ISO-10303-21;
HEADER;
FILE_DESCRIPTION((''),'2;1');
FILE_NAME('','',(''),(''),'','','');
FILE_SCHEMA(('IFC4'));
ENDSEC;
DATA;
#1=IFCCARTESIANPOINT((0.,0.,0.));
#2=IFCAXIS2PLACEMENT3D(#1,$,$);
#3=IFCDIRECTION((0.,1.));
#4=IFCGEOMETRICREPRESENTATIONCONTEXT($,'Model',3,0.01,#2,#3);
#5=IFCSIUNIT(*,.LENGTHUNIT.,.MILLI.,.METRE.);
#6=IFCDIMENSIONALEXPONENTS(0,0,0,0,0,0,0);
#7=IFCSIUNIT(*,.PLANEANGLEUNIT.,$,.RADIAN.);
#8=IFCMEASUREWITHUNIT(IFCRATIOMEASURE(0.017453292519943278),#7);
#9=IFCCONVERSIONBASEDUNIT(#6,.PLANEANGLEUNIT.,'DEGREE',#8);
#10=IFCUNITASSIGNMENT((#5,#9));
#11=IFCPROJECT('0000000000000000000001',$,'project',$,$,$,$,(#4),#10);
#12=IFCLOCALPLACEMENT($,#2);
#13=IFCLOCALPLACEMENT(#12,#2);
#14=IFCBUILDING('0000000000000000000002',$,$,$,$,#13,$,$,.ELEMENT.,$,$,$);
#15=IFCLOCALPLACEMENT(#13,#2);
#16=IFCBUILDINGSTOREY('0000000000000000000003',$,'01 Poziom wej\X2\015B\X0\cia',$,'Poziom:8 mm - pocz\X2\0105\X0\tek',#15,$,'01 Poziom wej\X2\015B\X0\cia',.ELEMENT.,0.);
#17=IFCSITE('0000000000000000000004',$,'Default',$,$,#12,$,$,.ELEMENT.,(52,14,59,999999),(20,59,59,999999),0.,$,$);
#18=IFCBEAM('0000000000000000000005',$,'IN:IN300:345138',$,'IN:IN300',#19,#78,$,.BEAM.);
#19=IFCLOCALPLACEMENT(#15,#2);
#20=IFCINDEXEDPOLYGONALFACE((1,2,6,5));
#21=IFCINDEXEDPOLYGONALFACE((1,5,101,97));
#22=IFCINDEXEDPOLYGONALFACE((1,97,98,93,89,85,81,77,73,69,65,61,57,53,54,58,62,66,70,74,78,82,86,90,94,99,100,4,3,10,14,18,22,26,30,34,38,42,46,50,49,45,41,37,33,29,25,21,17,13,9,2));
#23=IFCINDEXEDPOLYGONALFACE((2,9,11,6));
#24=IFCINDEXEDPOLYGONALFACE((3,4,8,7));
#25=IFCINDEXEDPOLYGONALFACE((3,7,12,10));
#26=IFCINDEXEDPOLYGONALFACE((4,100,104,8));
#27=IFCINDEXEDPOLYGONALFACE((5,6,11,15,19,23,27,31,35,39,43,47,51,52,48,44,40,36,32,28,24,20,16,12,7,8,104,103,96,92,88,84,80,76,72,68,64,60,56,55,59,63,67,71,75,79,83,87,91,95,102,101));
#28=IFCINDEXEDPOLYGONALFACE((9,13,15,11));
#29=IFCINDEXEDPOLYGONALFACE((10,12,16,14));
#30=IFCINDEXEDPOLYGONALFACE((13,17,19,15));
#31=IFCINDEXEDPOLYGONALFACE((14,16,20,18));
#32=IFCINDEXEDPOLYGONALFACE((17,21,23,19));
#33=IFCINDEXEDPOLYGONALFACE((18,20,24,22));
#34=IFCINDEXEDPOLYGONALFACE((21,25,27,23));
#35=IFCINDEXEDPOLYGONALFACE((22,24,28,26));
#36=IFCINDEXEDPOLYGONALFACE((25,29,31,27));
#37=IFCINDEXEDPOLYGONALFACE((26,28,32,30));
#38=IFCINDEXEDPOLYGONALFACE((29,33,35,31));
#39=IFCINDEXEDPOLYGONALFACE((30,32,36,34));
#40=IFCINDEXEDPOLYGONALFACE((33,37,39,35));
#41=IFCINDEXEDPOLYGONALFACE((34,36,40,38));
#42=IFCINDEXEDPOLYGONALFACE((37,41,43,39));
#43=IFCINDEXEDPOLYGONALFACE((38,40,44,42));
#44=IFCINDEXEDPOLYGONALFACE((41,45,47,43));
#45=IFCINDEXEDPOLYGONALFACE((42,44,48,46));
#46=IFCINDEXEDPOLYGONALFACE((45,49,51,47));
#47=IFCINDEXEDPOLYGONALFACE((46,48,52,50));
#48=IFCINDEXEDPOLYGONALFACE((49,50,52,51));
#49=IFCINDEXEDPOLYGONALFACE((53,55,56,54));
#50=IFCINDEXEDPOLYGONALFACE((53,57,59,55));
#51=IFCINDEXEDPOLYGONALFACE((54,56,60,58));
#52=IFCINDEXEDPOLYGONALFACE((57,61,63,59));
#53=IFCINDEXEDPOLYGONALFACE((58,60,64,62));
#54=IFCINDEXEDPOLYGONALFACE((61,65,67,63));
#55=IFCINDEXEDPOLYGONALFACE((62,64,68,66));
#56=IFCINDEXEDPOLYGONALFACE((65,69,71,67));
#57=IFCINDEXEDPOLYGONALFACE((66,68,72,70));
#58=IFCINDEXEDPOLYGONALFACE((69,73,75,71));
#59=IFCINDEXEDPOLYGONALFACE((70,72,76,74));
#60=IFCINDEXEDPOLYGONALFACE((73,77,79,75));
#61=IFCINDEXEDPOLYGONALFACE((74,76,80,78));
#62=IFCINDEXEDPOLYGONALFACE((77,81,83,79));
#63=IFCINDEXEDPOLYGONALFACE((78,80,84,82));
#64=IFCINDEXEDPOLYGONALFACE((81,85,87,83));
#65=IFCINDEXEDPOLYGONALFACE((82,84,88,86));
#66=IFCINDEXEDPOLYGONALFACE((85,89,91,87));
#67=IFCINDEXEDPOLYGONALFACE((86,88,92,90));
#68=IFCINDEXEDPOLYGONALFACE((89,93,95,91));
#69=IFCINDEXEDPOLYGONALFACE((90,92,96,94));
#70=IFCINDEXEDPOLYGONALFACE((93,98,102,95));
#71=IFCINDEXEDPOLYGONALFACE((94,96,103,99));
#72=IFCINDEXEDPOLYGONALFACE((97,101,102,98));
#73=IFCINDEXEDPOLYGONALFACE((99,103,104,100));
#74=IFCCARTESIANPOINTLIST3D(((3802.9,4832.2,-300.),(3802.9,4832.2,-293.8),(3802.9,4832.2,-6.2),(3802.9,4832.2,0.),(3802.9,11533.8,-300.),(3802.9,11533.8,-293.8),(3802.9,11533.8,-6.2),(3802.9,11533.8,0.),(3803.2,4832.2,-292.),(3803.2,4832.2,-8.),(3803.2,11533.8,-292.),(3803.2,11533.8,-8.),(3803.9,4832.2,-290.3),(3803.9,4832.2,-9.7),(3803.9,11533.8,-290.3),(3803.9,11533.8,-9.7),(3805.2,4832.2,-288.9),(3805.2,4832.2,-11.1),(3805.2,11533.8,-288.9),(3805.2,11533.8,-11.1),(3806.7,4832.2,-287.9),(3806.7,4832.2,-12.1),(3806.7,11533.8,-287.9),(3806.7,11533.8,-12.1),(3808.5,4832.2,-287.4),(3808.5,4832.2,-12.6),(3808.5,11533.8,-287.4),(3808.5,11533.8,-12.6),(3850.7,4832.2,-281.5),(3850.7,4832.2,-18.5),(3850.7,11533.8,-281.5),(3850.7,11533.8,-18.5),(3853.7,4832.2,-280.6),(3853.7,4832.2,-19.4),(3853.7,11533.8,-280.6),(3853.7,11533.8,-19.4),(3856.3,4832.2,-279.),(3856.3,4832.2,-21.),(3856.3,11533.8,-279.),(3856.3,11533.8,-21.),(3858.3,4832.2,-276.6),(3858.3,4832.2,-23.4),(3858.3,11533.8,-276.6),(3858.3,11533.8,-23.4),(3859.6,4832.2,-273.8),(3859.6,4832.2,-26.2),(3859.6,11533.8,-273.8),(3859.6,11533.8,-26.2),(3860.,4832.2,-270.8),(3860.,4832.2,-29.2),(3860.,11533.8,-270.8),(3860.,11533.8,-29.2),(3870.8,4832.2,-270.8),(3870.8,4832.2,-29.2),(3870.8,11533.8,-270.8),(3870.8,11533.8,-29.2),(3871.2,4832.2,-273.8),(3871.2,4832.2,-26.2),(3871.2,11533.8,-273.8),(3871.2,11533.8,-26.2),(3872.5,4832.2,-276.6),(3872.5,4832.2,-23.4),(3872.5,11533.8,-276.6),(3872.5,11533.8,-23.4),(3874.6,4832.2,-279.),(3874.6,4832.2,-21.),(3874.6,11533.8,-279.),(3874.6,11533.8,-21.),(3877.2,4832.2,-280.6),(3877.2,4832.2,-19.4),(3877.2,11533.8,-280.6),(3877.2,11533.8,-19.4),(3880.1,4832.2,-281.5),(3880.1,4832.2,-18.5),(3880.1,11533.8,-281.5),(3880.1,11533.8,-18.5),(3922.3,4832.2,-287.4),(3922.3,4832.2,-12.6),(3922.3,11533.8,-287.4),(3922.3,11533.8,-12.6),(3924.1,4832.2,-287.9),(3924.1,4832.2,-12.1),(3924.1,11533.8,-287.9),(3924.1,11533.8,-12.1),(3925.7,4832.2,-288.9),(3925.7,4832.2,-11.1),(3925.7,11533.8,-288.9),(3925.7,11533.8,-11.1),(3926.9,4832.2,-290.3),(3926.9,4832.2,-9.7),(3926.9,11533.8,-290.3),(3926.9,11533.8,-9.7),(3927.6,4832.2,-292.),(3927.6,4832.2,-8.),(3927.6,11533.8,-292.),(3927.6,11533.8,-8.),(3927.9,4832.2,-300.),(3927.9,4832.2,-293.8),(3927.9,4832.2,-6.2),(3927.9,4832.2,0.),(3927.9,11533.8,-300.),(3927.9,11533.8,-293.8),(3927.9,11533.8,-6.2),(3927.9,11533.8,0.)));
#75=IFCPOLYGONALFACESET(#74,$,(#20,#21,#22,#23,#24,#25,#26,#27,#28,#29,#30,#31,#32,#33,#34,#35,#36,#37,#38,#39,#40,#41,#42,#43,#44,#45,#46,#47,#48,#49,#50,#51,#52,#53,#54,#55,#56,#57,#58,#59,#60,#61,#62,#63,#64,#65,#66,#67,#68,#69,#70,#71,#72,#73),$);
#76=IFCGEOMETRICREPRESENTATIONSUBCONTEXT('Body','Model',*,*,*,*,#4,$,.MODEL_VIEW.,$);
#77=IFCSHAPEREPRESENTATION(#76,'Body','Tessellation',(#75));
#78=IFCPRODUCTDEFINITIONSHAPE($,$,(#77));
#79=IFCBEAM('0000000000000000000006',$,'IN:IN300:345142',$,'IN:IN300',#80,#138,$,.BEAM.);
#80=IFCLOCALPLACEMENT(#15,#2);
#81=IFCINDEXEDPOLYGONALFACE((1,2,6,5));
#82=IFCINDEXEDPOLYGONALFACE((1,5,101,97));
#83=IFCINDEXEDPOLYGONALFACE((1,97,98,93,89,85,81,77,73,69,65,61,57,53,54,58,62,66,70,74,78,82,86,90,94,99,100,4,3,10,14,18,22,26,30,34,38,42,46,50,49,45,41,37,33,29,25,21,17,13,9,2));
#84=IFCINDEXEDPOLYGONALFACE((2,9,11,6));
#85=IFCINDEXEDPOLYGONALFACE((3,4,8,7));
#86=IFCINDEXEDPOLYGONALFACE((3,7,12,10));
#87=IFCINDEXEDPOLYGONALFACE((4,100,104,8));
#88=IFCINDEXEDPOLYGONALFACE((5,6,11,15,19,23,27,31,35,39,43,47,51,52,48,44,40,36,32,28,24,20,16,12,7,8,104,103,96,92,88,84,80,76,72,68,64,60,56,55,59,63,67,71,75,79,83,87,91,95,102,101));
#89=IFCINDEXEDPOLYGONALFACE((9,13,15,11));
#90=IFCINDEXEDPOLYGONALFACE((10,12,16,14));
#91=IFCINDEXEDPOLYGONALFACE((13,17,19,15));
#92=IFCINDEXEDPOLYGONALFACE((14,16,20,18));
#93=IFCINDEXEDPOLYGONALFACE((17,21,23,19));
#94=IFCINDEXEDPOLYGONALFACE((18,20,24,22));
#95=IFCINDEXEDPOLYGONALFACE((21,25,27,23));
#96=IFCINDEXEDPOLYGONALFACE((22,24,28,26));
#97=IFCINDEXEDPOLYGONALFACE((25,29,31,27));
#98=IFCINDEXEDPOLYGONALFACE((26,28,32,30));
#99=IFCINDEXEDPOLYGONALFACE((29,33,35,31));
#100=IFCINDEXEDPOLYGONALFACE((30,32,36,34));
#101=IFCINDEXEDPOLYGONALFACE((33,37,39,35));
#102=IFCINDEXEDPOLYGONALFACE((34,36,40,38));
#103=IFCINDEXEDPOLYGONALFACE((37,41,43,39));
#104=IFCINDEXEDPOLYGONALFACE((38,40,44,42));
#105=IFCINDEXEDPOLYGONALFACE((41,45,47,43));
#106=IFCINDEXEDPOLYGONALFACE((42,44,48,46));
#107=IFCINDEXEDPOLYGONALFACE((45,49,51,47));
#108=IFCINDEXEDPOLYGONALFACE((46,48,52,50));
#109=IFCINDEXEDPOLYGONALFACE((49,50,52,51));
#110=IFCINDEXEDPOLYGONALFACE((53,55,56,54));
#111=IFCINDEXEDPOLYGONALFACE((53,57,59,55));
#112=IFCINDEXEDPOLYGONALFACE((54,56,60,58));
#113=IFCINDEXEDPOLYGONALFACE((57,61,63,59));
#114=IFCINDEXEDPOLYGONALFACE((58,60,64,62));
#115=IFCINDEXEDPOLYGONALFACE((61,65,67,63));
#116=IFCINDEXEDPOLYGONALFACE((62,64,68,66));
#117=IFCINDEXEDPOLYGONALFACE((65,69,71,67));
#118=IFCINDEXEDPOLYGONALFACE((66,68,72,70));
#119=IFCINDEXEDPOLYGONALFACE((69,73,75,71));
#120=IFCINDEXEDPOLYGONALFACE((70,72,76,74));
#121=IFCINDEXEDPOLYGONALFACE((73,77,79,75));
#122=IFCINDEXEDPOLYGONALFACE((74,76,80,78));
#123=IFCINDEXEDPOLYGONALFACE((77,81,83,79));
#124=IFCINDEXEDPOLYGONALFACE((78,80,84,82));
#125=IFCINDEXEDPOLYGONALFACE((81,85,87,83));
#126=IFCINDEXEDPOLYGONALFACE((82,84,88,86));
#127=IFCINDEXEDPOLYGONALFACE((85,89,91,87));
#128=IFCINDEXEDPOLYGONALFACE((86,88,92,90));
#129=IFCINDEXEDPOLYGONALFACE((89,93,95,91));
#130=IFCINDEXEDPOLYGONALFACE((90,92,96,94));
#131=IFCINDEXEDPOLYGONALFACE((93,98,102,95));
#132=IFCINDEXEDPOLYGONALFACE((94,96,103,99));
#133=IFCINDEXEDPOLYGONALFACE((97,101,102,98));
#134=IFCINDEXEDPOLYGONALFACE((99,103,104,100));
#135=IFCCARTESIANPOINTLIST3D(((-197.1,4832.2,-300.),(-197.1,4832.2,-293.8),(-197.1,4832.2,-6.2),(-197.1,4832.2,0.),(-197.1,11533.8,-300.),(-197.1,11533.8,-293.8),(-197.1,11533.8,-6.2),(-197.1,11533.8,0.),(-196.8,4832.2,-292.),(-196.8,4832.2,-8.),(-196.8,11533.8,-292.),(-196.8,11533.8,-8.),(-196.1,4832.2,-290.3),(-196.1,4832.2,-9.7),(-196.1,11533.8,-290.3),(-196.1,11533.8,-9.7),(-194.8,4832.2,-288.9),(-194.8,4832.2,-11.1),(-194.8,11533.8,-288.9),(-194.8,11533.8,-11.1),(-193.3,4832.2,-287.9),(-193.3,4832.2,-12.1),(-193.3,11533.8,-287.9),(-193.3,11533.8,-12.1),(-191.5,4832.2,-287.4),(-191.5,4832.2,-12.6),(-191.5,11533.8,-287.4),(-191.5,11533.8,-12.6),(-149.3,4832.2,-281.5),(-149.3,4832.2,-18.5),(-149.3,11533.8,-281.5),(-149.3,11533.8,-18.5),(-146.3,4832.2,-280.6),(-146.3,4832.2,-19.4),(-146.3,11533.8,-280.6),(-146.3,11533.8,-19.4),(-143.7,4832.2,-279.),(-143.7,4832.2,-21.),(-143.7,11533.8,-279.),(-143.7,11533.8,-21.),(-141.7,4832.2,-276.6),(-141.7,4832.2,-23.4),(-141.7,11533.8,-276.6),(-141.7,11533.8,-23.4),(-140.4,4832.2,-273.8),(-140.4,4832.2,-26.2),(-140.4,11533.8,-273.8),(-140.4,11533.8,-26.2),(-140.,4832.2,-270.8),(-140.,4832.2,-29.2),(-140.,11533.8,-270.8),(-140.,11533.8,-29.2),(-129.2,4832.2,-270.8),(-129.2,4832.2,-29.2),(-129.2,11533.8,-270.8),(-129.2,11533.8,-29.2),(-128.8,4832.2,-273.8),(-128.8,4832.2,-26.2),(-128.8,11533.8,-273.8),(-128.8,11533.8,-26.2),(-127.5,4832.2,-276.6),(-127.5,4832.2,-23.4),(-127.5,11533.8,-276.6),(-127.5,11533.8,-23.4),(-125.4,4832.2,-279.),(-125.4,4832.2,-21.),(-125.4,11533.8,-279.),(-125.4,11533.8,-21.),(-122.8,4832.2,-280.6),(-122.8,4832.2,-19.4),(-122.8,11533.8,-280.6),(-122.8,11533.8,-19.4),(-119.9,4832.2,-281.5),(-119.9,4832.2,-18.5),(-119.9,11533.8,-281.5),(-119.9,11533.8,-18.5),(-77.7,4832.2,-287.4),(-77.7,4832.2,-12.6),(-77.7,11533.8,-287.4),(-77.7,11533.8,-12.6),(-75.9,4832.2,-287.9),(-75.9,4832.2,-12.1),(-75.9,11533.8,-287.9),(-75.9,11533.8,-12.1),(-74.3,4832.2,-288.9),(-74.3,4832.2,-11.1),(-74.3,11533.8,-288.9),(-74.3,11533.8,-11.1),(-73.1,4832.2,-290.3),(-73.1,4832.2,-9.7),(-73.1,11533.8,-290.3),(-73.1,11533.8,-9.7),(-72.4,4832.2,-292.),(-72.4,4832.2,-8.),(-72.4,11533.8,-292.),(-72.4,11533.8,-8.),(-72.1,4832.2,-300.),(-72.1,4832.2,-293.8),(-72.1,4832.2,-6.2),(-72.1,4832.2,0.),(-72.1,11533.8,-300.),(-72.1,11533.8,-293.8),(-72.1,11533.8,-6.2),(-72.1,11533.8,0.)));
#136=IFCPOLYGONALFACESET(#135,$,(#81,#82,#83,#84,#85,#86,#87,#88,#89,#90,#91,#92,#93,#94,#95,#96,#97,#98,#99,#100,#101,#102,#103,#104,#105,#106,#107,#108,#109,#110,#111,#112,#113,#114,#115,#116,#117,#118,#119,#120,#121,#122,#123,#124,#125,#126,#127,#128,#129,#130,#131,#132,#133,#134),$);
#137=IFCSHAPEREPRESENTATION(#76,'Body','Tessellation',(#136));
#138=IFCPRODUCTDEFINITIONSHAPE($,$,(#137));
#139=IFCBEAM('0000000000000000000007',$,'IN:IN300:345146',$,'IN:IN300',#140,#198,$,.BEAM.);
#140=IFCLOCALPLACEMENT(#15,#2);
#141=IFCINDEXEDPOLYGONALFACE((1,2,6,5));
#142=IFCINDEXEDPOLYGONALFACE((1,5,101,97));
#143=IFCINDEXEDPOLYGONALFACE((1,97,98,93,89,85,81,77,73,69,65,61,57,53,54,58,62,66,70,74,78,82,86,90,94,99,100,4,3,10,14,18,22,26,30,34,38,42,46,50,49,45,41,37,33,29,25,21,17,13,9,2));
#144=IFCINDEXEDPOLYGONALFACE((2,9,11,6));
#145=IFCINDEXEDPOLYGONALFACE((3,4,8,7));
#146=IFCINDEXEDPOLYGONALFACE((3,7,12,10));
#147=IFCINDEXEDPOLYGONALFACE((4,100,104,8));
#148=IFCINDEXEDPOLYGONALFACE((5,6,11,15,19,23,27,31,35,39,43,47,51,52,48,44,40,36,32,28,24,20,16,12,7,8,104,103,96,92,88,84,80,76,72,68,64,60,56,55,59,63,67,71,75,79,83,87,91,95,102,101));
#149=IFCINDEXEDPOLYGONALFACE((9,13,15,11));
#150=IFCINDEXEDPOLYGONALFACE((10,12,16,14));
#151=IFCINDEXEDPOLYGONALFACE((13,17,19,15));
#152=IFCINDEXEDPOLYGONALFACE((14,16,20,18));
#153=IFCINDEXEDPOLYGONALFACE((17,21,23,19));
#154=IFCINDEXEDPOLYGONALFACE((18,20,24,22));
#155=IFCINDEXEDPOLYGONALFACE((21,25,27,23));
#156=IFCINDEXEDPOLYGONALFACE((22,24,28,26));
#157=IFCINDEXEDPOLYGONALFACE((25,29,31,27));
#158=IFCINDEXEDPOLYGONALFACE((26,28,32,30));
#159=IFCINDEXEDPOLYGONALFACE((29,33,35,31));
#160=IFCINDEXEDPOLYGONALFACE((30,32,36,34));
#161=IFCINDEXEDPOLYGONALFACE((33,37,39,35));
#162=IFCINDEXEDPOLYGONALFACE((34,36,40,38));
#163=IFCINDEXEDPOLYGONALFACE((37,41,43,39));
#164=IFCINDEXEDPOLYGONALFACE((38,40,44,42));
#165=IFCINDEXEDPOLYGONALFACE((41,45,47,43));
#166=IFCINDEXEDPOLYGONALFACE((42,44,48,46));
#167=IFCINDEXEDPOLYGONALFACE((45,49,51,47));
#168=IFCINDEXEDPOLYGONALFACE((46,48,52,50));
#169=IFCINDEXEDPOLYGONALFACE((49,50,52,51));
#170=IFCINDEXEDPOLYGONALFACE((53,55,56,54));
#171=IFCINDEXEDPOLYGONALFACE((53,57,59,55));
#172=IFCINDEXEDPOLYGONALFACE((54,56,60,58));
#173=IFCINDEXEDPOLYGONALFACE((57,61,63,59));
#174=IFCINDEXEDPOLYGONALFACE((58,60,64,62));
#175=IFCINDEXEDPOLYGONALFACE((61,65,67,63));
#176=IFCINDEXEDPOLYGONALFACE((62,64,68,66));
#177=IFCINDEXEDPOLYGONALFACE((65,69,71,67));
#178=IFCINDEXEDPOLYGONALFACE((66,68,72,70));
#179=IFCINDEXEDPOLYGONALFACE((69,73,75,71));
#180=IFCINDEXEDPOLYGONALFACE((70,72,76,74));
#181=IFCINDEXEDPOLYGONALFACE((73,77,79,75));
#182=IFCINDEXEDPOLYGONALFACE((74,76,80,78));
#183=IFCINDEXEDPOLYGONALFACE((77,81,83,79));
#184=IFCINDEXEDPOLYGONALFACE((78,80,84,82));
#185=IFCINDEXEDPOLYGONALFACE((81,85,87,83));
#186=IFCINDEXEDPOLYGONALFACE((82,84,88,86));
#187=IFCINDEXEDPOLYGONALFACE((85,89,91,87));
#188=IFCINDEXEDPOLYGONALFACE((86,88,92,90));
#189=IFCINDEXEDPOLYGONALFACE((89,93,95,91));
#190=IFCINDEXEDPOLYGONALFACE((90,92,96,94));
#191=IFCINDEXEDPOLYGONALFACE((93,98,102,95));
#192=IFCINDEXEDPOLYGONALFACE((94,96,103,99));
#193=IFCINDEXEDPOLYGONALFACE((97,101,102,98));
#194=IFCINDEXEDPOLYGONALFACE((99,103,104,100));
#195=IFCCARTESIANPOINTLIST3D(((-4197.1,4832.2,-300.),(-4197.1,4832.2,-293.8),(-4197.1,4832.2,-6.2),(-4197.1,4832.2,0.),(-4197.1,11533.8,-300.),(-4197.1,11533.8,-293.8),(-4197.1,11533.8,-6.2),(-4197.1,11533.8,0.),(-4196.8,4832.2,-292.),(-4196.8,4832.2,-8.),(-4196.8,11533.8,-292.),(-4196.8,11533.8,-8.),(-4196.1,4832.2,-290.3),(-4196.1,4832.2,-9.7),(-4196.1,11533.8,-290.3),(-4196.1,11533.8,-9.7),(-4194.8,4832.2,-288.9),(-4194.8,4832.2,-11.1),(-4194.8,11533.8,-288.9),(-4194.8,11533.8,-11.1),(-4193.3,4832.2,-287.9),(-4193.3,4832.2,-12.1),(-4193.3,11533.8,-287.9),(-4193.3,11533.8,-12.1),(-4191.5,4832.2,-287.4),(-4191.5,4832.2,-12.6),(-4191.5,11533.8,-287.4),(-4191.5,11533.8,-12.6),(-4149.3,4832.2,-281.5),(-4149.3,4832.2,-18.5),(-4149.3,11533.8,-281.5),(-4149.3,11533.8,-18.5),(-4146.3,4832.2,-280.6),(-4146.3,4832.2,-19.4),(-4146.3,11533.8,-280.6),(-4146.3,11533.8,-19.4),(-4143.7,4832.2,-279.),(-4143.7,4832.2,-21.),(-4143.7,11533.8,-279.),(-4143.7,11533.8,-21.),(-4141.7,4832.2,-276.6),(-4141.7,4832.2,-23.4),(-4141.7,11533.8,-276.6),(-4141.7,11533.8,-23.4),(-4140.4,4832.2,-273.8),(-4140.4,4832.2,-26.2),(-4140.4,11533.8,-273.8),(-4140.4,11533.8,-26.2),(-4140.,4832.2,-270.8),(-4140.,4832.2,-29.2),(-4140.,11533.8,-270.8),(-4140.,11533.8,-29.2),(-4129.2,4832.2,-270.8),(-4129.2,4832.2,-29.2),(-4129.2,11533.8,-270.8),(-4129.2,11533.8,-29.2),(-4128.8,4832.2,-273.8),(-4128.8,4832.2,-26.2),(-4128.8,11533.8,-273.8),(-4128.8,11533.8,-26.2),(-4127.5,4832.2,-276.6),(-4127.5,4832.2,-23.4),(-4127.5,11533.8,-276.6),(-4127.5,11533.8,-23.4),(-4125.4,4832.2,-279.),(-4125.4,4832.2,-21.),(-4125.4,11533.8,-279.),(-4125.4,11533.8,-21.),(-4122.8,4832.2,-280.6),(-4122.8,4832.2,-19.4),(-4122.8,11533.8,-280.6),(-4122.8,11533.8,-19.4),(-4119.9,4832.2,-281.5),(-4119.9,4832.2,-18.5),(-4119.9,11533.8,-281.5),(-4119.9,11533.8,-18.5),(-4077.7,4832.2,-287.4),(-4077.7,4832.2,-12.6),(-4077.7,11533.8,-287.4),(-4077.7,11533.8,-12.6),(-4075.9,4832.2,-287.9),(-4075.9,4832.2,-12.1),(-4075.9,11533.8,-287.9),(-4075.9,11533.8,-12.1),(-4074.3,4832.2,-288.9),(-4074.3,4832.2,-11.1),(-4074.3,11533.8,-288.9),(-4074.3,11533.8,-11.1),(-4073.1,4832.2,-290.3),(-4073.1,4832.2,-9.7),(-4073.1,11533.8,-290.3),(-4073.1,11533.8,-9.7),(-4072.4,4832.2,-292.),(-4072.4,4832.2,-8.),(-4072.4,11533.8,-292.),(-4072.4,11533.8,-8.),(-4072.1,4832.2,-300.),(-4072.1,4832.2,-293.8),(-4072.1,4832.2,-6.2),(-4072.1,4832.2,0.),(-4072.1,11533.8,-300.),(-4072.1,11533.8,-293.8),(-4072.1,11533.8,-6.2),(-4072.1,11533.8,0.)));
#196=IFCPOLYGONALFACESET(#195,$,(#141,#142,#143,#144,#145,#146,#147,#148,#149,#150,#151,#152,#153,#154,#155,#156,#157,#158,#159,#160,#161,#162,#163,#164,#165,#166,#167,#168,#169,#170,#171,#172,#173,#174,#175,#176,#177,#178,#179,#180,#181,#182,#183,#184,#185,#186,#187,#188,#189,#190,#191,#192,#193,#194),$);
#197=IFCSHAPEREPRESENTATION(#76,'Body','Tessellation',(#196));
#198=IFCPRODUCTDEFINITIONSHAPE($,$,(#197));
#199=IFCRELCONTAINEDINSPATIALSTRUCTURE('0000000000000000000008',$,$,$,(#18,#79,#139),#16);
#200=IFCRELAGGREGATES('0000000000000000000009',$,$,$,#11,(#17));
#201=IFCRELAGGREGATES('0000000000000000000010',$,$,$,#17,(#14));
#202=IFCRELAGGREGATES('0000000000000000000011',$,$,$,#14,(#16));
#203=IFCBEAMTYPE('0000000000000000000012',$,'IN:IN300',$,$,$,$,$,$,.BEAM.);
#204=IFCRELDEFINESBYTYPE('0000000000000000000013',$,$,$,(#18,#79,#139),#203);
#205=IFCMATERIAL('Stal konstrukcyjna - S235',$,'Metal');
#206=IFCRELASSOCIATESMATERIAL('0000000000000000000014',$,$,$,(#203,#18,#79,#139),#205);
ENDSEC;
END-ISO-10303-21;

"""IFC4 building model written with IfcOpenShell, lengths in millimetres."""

from ifc_helpers import new_model, entity, si_unit, converted_unit, direction, frame, origin, place, context, subcontext, project, spatial, line, arc, indexed_curve, outline, extrude, source, transform, mapped, material, type_object, type_shapes, element, save


model = new_model("IFC4")

# Units and contexts
model_context = context("Model", 3, precision=0.01, world=origin(), true_north=direction((0.0, 1.0)))
body_context = subcontext(model_context, "Body", "Model", "MODEL_VIEW")
ifc_project = project(units=[si_unit("LENGTHUNIT", "METRE", prefix="MILLI"), converted_unit("PLANEANGLEUNIT", "DEGREE", entity("IfcRatioMeasure", 0.017453292519943278), si_unit("PLANEANGLEUNIT", "RADIAN"), dimensions=[0, 0, 0, 0, 0, 0, 0])], contexts=[model_context])

# Site, building, storey
site_placement = place(None, origin())
site = spatial("IfcSite", under=ifc_project, at=site_placement, Name="Default", CompositionType="ELEMENT", RefLatitude=(52, 14, 59, 999999), RefLongitude=(20, 59, 59, 999999), RefElevation=0.0)
building_placement = place(site_placement, origin())
building = spatial("IfcBuilding", under=site, at=building_placement, CompositionType="ELEMENT")
storey_placement = place(building_placement, origin())
storey = spatial("IfcBuildingStorey", under=building, at=storey_placement, Name="01 Poziom wejścia", ObjectType="Poziom:8 mm - początek", LongName="01 Poziom wejścia", CompositionType="ELEMENT", Elevation=0.0)

# Beams
ifc_material = material(Name="Stal konstrukcyjna - S235", Category="Metal")
beam_type_1 = type_object("IfcBeamType", Name="IN:IN300", PredefinedType="BEAM", material=ifc_material)
shared_shape_1 = source(origin(), body_context, "Body", "SweptSolid", [
    extrude(outline(indexed_curve([(143.8, -62.5), (150.0, -62.5), (150.0, 62.5), (143.8, 62.5), (139.6, 60.9), (137.4, 56.9), (131.5, 14.7), (127.9, 8.1), (120.8, 5.4), (-120.8, 5.4), (-127.9, 8.1), (-131.5, 14.7), (-137.4, 56.9), (-139.6, 60.9), (-143.8, 62.5), (-150.0, 62.5), (-150.0, -62.5), (-143.8, -62.5), (-139.6, -60.9), (-137.4, -56.9), (-131.5, -14.7), (-127.9, -8.1), (-120.8, -5.4), (120.8, -5.4), (127.9, -8.1), (131.5, -14.7), (137.4, -56.9), (139.6, -60.9)], segments=[line(1, 2, 3, 4), arc(4, 5, 6), line(6, 7), arc(7, 8, 9), line(9, 10), arc(10, 11, 12), line(12, 13), arc(13, 14, 15), line(15, 16, 17, 18), arc(18, 19, 20), line(20, 21), arc(21, 22, 23), line(23, 24), arc(24, 25, 26), line(26, 27), arc(27, 28, 1)], self_intersect=False)), frame((-3350.8, 0.0, 0.0), z_axis=(1.0, 0.0, 0.0), x_axis=(0.0, 0.0, -1.0)), (0.0, 0.0, 1.0), 6701.6),
])
type_shapes(beam_type_1, [shared_shape_1])
for number, where, z_axis, x_axis, name in (
    (1, (3865.4, 8183.0, -150.0), (0.0, 0.0, 1.0), (0.0, -1.0, 0.0), "IN:IN300:345138"),
    (2, (-134.6, 8183.0, -150.0), (0.0, 0.0, 1.0), (0.0, -1.0, 0.0), "IN:IN300:345142"),
    (3, (-4134.6, 8183.0, -150.0), (0.0, 0.0, 1.0), (0.0, -1.0, 0.0), "IN:IN300:345146"),
):
    element("IfcBeam", number, at=place(storey_placement, frame(where, z_axis=z_axis, x_axis=x_axis)), inside=storey, type_object=beam_type_1, material=ifc_material, Name=name, ObjectType="IN:IN300", PredefinedType="BEAM", context=body_context, shape_type="MappedRepresentation", body=[
        mapped(shared_shape_1, transform((0.0, 0.0, 0.0), scale=1.0)),
    ])

save(model, "model.ifc")
